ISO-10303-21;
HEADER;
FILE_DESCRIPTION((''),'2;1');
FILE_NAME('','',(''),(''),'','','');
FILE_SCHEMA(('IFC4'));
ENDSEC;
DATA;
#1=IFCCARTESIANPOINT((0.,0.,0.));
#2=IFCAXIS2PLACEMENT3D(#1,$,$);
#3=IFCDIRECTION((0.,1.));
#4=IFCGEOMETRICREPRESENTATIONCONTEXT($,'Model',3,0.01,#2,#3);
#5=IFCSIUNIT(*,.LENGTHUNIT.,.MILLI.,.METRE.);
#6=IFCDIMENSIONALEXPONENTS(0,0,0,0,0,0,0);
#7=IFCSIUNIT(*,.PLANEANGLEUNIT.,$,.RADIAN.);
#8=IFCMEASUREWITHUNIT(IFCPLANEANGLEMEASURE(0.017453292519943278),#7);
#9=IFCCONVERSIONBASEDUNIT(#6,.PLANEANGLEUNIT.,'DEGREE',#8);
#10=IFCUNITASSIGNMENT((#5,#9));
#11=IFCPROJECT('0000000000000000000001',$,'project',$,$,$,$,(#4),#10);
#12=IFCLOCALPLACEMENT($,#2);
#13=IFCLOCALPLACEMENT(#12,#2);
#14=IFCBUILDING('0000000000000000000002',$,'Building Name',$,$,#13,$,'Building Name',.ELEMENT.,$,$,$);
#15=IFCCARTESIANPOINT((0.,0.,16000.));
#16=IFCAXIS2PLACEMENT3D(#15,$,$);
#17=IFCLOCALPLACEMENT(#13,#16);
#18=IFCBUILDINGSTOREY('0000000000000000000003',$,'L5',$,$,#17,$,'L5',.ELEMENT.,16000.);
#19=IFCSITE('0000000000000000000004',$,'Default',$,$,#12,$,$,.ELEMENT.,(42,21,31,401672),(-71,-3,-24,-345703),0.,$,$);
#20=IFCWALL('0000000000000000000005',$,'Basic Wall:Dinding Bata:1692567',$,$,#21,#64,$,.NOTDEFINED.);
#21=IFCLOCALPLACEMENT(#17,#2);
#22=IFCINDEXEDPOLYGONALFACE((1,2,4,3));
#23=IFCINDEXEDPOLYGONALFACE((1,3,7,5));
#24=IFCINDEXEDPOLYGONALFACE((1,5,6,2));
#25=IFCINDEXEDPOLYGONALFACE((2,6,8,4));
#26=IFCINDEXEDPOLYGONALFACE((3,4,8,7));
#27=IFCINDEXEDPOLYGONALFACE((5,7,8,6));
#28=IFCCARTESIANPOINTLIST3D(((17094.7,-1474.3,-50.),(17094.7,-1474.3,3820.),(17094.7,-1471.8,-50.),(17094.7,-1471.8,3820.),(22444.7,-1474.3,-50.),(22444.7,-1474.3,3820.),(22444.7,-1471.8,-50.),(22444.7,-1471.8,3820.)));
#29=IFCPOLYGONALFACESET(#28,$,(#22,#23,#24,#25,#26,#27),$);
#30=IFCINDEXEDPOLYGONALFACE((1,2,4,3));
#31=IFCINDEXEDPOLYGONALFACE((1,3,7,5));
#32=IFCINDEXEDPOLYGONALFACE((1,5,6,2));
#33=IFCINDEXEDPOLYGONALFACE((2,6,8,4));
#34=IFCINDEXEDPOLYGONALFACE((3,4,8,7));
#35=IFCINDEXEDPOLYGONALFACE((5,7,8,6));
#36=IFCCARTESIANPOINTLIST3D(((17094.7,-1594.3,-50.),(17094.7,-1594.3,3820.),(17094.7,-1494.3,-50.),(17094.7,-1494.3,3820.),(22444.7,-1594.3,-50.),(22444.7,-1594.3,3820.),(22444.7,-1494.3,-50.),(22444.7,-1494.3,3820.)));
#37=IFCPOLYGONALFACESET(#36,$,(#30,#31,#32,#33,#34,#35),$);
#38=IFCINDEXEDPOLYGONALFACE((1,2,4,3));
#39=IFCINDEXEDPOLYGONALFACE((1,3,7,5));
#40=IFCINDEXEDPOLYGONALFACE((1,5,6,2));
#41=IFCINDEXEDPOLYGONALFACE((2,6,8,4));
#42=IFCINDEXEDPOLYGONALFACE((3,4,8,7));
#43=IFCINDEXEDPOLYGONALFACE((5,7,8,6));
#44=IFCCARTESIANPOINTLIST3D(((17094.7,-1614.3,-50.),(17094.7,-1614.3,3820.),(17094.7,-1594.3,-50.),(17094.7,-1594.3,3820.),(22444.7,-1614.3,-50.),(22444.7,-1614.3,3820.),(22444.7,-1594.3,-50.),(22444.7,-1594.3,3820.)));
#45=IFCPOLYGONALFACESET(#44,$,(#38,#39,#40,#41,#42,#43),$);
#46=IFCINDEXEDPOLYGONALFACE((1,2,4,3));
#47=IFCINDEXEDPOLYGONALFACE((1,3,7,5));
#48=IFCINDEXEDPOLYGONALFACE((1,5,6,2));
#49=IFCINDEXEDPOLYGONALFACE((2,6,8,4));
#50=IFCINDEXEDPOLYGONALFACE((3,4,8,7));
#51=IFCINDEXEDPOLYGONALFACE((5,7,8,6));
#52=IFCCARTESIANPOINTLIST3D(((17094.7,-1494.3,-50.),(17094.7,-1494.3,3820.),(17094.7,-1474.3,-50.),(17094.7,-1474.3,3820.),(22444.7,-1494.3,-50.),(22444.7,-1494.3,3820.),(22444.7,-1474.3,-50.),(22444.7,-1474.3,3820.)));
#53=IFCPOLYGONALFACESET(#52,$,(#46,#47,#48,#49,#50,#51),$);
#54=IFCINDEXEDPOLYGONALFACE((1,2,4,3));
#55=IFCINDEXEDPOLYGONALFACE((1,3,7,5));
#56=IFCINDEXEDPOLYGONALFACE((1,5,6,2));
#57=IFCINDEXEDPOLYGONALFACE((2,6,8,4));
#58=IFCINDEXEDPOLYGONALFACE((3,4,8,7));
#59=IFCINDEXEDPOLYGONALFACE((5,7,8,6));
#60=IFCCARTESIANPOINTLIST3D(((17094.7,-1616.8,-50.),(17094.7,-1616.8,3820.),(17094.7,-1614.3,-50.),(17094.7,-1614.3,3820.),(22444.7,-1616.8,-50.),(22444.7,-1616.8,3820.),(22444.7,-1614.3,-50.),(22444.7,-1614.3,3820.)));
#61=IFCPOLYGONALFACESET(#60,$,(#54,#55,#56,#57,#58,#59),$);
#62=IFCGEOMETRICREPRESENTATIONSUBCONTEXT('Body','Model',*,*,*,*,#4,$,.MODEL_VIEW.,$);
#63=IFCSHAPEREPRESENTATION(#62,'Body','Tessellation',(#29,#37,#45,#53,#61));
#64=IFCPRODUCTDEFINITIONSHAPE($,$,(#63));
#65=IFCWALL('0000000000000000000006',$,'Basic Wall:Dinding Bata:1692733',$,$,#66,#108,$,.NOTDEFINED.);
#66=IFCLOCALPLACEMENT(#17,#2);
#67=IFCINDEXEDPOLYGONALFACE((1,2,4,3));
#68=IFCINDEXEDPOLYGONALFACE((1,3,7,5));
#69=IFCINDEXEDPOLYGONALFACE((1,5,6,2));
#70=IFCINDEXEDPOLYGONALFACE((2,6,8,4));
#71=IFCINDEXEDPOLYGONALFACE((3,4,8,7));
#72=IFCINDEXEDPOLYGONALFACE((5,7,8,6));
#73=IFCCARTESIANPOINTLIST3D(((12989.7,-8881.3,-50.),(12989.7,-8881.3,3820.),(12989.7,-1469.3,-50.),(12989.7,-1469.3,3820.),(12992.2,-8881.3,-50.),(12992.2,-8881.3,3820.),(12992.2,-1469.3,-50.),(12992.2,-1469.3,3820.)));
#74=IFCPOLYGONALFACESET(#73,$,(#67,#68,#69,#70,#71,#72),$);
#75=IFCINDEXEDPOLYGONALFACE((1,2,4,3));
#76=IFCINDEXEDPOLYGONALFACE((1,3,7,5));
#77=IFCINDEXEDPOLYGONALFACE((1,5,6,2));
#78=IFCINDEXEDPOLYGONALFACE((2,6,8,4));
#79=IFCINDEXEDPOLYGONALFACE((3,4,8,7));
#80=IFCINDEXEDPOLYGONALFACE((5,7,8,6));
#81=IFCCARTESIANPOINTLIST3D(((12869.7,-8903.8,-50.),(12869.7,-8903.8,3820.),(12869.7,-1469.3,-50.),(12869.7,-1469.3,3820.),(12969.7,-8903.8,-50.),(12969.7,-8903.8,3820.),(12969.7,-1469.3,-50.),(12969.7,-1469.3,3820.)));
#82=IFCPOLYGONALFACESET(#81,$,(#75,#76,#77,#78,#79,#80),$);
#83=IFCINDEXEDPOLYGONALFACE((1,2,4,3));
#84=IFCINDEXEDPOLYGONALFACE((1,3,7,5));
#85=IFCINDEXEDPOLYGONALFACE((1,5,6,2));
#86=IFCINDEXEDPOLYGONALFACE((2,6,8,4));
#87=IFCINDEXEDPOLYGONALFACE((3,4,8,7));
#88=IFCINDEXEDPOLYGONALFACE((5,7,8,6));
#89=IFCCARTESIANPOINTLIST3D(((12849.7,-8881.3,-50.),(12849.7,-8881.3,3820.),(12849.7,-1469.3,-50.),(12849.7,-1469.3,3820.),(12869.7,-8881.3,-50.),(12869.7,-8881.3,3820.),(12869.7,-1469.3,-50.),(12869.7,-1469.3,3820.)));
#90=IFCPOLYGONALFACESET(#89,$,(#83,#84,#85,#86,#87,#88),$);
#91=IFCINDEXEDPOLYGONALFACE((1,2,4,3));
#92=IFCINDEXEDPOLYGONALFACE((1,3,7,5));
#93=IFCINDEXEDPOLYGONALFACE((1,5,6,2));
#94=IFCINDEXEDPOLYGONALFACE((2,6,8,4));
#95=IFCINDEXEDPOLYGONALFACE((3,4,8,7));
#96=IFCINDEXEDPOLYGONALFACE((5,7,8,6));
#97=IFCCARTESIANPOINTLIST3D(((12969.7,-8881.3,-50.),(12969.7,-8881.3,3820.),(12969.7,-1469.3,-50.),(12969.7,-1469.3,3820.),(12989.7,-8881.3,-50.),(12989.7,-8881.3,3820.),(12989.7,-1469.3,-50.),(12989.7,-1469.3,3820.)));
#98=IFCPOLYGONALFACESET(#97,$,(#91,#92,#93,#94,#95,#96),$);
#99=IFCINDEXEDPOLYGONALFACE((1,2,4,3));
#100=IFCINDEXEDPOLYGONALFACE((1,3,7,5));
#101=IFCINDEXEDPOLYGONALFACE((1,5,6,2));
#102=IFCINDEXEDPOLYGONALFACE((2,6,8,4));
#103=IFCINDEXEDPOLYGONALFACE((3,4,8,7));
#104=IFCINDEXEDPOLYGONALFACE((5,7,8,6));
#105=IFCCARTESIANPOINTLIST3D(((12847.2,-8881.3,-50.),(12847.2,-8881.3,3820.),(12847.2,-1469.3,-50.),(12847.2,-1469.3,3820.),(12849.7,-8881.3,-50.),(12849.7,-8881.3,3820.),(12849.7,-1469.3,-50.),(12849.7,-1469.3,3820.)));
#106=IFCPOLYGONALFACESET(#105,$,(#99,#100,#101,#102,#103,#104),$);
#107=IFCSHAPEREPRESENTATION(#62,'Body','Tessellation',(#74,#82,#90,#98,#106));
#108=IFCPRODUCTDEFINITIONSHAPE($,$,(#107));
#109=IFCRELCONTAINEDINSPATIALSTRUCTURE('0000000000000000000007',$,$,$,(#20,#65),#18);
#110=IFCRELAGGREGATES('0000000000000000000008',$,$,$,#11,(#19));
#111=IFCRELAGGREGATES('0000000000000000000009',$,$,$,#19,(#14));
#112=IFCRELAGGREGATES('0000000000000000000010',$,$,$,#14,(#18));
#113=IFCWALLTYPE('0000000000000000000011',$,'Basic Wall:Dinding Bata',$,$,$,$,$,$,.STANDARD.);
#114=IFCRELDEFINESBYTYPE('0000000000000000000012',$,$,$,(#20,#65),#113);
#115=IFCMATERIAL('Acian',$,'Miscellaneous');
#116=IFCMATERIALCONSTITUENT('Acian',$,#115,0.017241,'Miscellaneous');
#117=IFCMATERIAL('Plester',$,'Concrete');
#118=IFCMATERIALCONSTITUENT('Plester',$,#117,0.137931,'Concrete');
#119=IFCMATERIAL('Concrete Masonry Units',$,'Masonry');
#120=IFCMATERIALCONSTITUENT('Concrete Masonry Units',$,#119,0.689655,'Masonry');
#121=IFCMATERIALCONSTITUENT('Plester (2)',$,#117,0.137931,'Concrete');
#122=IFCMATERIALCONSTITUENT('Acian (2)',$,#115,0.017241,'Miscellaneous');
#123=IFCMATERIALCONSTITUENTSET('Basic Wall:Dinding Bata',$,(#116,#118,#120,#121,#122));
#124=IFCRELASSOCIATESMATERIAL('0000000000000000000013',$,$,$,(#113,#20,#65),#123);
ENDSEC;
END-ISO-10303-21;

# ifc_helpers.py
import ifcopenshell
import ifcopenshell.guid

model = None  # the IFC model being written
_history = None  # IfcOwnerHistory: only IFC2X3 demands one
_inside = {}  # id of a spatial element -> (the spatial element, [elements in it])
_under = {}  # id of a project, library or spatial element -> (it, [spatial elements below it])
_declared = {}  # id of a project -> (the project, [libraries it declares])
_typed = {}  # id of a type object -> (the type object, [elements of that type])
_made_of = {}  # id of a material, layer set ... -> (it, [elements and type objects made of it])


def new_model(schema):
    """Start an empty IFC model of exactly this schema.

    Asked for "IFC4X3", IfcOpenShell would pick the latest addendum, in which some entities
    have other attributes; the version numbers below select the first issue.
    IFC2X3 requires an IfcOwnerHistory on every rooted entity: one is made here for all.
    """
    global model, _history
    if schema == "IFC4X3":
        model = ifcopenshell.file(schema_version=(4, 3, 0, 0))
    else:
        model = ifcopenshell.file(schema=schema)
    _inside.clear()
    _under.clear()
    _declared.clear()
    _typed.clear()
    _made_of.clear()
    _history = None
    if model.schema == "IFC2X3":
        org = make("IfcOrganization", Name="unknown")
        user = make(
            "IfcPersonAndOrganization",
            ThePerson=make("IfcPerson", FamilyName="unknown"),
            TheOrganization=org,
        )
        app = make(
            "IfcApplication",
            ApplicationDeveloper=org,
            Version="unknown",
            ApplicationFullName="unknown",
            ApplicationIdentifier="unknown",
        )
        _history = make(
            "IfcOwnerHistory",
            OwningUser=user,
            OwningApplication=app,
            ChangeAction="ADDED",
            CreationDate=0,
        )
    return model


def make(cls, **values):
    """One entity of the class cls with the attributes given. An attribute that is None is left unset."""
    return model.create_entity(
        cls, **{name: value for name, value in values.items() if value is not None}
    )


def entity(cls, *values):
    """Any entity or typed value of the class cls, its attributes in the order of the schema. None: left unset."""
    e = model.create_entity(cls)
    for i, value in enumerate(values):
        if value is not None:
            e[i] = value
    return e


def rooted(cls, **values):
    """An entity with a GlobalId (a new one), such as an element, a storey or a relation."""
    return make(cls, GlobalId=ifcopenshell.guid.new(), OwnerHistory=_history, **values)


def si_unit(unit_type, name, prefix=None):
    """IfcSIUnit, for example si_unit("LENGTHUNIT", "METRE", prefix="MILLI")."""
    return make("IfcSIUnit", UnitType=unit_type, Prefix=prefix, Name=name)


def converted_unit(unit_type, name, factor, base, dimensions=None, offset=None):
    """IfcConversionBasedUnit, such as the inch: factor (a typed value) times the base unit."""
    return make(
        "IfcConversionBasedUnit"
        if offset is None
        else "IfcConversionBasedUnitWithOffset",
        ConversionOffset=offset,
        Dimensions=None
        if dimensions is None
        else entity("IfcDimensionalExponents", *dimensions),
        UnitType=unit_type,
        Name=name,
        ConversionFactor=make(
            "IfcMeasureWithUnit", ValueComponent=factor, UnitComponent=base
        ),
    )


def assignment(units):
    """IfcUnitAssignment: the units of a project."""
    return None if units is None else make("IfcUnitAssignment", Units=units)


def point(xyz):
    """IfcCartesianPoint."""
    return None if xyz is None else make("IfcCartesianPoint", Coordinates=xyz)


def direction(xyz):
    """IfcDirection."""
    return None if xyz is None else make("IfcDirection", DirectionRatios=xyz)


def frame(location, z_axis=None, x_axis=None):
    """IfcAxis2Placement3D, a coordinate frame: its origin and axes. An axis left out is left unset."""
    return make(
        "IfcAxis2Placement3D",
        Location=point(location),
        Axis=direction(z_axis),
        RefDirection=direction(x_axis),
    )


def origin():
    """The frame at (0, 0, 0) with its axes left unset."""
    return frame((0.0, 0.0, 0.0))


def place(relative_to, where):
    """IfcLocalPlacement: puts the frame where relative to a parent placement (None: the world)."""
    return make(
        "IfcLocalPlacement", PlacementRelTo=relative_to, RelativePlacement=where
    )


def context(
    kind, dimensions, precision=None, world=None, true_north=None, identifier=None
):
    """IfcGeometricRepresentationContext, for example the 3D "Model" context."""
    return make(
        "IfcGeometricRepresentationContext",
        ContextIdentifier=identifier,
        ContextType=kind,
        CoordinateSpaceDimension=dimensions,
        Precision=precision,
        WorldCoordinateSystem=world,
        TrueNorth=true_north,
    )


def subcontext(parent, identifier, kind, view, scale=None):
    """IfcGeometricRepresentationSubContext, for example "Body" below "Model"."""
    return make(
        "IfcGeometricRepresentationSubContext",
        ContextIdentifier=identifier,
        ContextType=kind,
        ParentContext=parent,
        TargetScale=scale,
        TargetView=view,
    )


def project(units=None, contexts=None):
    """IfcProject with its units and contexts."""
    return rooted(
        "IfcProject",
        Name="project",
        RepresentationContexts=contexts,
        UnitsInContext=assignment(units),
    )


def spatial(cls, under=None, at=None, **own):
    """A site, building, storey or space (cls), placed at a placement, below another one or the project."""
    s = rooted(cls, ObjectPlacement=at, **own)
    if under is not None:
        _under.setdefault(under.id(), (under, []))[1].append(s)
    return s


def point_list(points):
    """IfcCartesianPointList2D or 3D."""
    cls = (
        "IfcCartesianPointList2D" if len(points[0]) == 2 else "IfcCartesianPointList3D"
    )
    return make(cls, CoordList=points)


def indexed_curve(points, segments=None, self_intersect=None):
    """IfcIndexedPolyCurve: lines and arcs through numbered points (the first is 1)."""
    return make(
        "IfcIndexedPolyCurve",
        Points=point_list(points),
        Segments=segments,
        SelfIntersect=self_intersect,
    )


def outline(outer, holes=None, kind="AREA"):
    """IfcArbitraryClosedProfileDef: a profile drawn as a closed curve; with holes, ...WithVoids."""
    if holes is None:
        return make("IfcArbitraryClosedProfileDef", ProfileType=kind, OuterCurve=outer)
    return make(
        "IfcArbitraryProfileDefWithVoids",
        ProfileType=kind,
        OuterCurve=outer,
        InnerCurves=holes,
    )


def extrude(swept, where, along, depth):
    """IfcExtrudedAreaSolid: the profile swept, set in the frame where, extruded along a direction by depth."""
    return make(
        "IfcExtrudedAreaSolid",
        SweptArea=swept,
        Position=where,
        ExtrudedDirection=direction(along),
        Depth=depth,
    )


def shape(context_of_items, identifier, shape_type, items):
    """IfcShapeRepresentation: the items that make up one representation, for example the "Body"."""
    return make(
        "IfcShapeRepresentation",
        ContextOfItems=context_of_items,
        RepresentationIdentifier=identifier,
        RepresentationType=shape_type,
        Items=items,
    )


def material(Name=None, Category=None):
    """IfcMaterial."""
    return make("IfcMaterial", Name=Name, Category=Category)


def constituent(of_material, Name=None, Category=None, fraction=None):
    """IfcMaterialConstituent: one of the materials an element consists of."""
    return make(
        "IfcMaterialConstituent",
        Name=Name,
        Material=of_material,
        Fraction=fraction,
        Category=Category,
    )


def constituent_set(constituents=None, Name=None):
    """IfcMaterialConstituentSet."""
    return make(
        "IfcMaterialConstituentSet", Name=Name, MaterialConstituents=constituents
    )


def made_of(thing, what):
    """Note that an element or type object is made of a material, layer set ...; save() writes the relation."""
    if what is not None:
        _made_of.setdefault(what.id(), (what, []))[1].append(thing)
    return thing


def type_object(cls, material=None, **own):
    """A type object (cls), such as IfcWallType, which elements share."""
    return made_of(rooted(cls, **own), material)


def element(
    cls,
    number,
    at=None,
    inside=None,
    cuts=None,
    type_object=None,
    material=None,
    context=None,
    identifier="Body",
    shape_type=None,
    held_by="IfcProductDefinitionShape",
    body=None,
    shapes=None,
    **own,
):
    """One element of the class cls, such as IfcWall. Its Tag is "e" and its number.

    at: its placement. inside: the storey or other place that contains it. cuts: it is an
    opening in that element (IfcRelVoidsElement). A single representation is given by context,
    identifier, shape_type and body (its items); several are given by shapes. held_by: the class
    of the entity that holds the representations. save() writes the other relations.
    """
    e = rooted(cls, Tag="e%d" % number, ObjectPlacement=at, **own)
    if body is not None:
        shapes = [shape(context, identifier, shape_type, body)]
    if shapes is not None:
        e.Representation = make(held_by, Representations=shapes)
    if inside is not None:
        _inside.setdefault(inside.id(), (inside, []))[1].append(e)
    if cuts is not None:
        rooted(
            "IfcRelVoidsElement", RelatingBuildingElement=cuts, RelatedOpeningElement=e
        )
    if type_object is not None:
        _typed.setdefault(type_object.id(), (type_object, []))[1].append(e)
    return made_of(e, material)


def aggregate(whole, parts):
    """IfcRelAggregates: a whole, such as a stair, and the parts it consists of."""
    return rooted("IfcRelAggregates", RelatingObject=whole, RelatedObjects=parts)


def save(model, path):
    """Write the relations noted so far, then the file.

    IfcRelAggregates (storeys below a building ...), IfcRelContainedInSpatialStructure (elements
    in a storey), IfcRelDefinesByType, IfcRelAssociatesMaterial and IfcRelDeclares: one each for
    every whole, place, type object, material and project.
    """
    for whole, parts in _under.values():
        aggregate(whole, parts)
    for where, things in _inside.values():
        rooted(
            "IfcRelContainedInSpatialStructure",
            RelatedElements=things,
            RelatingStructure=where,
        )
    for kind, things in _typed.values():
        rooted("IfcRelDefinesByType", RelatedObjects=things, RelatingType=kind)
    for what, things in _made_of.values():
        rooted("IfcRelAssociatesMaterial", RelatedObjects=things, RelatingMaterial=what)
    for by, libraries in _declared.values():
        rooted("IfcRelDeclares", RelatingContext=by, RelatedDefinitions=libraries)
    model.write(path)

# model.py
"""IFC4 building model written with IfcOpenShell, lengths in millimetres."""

from ifc_helpers import new_model, entity, si_unit, converted_unit, direction, frame, origin, place, context, subcontext, project, spatial, indexed_curve, outline, extrude, material, constituent, constituent_set, type_object, element, save


model = new_model("IFC4")

# Units and contexts
model_context = context("Model", 3, precision=0.01, world=origin(), true_north=direction((0.0, 1.0)))
body_context = subcontext(model_context, "Body", "Model", "MODEL_VIEW")
ifc_project = project(units=[si_unit("LENGTHUNIT", "METRE", prefix="MILLI"), converted_unit("PLANEANGLEUNIT", "DEGREE", entity("IfcPlaneAngleMeasure", 0.017453292519943278), si_unit("PLANEANGLEUNIT", "RADIAN"), dimensions=[0, 0, 0, 0, 0, 0, 0])], contexts=[model_context])

# Site, building, storey
site_placement = place(None, origin())
site = spatial("IfcSite", under=ifc_project, at=site_placement, Name="Default", CompositionType="ELEMENT", RefLatitude=(42, 21, 31, 401672), RefLongitude=(-71, -3, -24, -345703), RefElevation=0.0)
building_placement = place(site_placement, origin())
building = spatial("IfcBuilding", under=site, at=building_placement, Name="Building Name", LongName="Building Name", CompositionType="ELEMENT")
storey_placement = place(building_placement, frame((0.0, 0.0, 16000.0)))
storey = spatial("IfcBuildingStorey", under=building, at=storey_placement, Name="L5", LongName="L5", CompositionType="ELEMENT", Elevation=16000.0)

# Walls
ifc_material_1 = material(Name="Acian", Category="Miscellaneous")
ifc_constituent_1 = constituent(ifc_material_1, Name="Acian", Category="Miscellaneous", fraction=0.017241)
ifc_material_2 = material(Name="Plester", Category="Concrete")
ifc_constituent_2 = constituent(ifc_material_2, Name="Plester", Category="Concrete", fraction=0.137931)
ifc_material_3 = material(Name="Concrete Masonry Units", Category="Masonry")
ifc_constituent_3 = constituent(ifc_material_3, Name="Concrete Masonry Units", Category="Masonry", fraction=0.689655)
ifc_constituent_4 = constituent(ifc_material_2, Name="Plester (2)", Category="Concrete", fraction=0.137931)
ifc_constituent_5 = constituent(ifc_material_1, Name="Acian (2)", Category="Miscellaneous", fraction=0.017241)
ifc_constituent_set = constituent_set(constituents=[ifc_constituent_1, ifc_constituent_2, ifc_constituent_3, ifc_constituent_4, ifc_constituent_5], Name="Basic Wall:Dinding Bata")
wall_type = type_object("IfcWallType", Name="Basic Wall:Dinding Bata", PredefinedType="STANDARD", material=ifc_constituent_set)
wall_1_placement = place(storey_placement, frame((17094.7, -1544.3, -50.0)))
element("IfcWall", 1, at=wall_1_placement, inside=storey, type_object=wall_type, material=ifc_constituent_set, Name="Basic Wall:Dinding Bata:1692567", PredefinedType="NOTDEFINED", context=body_context, shape_type="SweptSolid", body=[
    extrude(outline(indexed_curve([(-1.3, -2675.0), (1.2, -2675.0), (1.3, 2675.0), (-1.2, 2675.0), (-1.3, -2675.0)], self_intersect=False)), frame((2675.0, 71.3, 0.0), z_axis=(0.0, 0.0, 1.0), x_axis=(0.0, -1.0, 0.0)), (0.0, 0.0, 1.0), 3870.0),
    extrude(outline(indexed_curve([(-2675.0, -50.0), (2675.0, -50.0), (2675.0, 50.0), (-2675.0, 50.0), (-2675.0, -50.0)], self_intersect=False)), frame((2675.0, 0.0, 0.0)), (0.0, 0.0, 1.0), 3870.0),
    extrude(outline(indexed_curve([(-2675.0, -10.0), (2675.0, -10.0), (2675.0, 10.0), (-2675.0, 10.0), (-2675.0, -10.0)], self_intersect=False)), frame((2675.0, -60.0, 0.0)), (0.0, 0.0, 1.0), 3870.0),
    extrude(outline(indexed_curve([(-2675.0, -10.0), (2675.0, -10.0), (2675.0, 10.0), (-2675.0, 10.0), (-2675.0, -10.0)], self_intersect=False)), frame((2675.0, 60.0, 0.0)), (0.0, 0.0, 1.0), 3870.0),
    extrude(outline(indexed_curve([(-1.3, -2675.0), (1.2, -2675.0), (1.3, 2675.0), (-1.2, 2675.0), (-1.3, -2675.0)], self_intersect=False)), frame((2675.0, -71.3, 0.0), z_axis=(0.0, 0.0, 1.0), x_axis=(0.0, 1.0, 0.0)), (0.0, 0.0, 1.0), 3870.0),
])
wall_2_placement = place(storey_placement, frame((12919.7, -1469.3, -50.0), z_axis=(0.0, 0.0, 1.0), x_axis=(0.0, -1.0, 0.0)))
element("IfcWall", 2, at=wall_2_placement, inside=storey, type_object=wall_type, material=ifc_constituent_set, Name="Basic Wall:Dinding Bata:1692733", PredefinedType="NOTDEFINED", context=body_context, shape_type="SweptSolid", body=[
    extrude(outline(indexed_curve([(-1.3, -3706.0), (1.2, -3706.0), (1.3, 3706.0), (-1.2, 3706.0), (-1.3, -3706.0)], self_intersect=False)), frame((3706.0, 71.2, 0.0), z_axis=(0.0, 0.0, 1.0), x_axis=(0.0, -1.0, 0.0)), (0.0, 0.0, 1.0), 3870.0),
    extrude(outline(indexed_curve([(-3717.3, -50.0), (3717.3, -50.0), (3717.3, 50.0), (-3717.3, 50.0), (-3717.3, -50.0)], self_intersect=False)), frame((3717.3, 0.0, 0.0)), (0.0, 0.0, 1.0), 3870.0),
    extrude(outline(indexed_curve([(-3706.0, -10.0), (3706.0, -10.0), (3706.0, 10.0), (-3706.0, 10.0), (-3706.0, -10.0)], self_intersect=False)), frame((3706.0, -60.0, 0.0)), (0.0, 0.0, 1.0), 3870.0),
    extrude(outline(indexed_curve([(-3706.0, -10.0), (3706.0, -10.0), (3706.0, 10.0), (-3706.0, 10.0), (-3706.0, -10.0)], self_intersect=False)), frame((3706.0, 60.0, 0.0)), (0.0, 0.0, 1.0), 3870.0),
    extrude(outline(indexed_curve([(-1.3, -3706.0), (1.2, -3706.0), (1.3, 3706.0), (-1.2, 3706.0), (-1.3, -3706.0)], self_intersect=False)), frame((3706.0, -71.2, 0.0), z_axis=(0.0, 0.0, 1.0), x_axis=(0.0, 1.0, 0.0)), (0.0, 0.0, 1.0), 3870.0),
])

save(model, "model.ifc")
